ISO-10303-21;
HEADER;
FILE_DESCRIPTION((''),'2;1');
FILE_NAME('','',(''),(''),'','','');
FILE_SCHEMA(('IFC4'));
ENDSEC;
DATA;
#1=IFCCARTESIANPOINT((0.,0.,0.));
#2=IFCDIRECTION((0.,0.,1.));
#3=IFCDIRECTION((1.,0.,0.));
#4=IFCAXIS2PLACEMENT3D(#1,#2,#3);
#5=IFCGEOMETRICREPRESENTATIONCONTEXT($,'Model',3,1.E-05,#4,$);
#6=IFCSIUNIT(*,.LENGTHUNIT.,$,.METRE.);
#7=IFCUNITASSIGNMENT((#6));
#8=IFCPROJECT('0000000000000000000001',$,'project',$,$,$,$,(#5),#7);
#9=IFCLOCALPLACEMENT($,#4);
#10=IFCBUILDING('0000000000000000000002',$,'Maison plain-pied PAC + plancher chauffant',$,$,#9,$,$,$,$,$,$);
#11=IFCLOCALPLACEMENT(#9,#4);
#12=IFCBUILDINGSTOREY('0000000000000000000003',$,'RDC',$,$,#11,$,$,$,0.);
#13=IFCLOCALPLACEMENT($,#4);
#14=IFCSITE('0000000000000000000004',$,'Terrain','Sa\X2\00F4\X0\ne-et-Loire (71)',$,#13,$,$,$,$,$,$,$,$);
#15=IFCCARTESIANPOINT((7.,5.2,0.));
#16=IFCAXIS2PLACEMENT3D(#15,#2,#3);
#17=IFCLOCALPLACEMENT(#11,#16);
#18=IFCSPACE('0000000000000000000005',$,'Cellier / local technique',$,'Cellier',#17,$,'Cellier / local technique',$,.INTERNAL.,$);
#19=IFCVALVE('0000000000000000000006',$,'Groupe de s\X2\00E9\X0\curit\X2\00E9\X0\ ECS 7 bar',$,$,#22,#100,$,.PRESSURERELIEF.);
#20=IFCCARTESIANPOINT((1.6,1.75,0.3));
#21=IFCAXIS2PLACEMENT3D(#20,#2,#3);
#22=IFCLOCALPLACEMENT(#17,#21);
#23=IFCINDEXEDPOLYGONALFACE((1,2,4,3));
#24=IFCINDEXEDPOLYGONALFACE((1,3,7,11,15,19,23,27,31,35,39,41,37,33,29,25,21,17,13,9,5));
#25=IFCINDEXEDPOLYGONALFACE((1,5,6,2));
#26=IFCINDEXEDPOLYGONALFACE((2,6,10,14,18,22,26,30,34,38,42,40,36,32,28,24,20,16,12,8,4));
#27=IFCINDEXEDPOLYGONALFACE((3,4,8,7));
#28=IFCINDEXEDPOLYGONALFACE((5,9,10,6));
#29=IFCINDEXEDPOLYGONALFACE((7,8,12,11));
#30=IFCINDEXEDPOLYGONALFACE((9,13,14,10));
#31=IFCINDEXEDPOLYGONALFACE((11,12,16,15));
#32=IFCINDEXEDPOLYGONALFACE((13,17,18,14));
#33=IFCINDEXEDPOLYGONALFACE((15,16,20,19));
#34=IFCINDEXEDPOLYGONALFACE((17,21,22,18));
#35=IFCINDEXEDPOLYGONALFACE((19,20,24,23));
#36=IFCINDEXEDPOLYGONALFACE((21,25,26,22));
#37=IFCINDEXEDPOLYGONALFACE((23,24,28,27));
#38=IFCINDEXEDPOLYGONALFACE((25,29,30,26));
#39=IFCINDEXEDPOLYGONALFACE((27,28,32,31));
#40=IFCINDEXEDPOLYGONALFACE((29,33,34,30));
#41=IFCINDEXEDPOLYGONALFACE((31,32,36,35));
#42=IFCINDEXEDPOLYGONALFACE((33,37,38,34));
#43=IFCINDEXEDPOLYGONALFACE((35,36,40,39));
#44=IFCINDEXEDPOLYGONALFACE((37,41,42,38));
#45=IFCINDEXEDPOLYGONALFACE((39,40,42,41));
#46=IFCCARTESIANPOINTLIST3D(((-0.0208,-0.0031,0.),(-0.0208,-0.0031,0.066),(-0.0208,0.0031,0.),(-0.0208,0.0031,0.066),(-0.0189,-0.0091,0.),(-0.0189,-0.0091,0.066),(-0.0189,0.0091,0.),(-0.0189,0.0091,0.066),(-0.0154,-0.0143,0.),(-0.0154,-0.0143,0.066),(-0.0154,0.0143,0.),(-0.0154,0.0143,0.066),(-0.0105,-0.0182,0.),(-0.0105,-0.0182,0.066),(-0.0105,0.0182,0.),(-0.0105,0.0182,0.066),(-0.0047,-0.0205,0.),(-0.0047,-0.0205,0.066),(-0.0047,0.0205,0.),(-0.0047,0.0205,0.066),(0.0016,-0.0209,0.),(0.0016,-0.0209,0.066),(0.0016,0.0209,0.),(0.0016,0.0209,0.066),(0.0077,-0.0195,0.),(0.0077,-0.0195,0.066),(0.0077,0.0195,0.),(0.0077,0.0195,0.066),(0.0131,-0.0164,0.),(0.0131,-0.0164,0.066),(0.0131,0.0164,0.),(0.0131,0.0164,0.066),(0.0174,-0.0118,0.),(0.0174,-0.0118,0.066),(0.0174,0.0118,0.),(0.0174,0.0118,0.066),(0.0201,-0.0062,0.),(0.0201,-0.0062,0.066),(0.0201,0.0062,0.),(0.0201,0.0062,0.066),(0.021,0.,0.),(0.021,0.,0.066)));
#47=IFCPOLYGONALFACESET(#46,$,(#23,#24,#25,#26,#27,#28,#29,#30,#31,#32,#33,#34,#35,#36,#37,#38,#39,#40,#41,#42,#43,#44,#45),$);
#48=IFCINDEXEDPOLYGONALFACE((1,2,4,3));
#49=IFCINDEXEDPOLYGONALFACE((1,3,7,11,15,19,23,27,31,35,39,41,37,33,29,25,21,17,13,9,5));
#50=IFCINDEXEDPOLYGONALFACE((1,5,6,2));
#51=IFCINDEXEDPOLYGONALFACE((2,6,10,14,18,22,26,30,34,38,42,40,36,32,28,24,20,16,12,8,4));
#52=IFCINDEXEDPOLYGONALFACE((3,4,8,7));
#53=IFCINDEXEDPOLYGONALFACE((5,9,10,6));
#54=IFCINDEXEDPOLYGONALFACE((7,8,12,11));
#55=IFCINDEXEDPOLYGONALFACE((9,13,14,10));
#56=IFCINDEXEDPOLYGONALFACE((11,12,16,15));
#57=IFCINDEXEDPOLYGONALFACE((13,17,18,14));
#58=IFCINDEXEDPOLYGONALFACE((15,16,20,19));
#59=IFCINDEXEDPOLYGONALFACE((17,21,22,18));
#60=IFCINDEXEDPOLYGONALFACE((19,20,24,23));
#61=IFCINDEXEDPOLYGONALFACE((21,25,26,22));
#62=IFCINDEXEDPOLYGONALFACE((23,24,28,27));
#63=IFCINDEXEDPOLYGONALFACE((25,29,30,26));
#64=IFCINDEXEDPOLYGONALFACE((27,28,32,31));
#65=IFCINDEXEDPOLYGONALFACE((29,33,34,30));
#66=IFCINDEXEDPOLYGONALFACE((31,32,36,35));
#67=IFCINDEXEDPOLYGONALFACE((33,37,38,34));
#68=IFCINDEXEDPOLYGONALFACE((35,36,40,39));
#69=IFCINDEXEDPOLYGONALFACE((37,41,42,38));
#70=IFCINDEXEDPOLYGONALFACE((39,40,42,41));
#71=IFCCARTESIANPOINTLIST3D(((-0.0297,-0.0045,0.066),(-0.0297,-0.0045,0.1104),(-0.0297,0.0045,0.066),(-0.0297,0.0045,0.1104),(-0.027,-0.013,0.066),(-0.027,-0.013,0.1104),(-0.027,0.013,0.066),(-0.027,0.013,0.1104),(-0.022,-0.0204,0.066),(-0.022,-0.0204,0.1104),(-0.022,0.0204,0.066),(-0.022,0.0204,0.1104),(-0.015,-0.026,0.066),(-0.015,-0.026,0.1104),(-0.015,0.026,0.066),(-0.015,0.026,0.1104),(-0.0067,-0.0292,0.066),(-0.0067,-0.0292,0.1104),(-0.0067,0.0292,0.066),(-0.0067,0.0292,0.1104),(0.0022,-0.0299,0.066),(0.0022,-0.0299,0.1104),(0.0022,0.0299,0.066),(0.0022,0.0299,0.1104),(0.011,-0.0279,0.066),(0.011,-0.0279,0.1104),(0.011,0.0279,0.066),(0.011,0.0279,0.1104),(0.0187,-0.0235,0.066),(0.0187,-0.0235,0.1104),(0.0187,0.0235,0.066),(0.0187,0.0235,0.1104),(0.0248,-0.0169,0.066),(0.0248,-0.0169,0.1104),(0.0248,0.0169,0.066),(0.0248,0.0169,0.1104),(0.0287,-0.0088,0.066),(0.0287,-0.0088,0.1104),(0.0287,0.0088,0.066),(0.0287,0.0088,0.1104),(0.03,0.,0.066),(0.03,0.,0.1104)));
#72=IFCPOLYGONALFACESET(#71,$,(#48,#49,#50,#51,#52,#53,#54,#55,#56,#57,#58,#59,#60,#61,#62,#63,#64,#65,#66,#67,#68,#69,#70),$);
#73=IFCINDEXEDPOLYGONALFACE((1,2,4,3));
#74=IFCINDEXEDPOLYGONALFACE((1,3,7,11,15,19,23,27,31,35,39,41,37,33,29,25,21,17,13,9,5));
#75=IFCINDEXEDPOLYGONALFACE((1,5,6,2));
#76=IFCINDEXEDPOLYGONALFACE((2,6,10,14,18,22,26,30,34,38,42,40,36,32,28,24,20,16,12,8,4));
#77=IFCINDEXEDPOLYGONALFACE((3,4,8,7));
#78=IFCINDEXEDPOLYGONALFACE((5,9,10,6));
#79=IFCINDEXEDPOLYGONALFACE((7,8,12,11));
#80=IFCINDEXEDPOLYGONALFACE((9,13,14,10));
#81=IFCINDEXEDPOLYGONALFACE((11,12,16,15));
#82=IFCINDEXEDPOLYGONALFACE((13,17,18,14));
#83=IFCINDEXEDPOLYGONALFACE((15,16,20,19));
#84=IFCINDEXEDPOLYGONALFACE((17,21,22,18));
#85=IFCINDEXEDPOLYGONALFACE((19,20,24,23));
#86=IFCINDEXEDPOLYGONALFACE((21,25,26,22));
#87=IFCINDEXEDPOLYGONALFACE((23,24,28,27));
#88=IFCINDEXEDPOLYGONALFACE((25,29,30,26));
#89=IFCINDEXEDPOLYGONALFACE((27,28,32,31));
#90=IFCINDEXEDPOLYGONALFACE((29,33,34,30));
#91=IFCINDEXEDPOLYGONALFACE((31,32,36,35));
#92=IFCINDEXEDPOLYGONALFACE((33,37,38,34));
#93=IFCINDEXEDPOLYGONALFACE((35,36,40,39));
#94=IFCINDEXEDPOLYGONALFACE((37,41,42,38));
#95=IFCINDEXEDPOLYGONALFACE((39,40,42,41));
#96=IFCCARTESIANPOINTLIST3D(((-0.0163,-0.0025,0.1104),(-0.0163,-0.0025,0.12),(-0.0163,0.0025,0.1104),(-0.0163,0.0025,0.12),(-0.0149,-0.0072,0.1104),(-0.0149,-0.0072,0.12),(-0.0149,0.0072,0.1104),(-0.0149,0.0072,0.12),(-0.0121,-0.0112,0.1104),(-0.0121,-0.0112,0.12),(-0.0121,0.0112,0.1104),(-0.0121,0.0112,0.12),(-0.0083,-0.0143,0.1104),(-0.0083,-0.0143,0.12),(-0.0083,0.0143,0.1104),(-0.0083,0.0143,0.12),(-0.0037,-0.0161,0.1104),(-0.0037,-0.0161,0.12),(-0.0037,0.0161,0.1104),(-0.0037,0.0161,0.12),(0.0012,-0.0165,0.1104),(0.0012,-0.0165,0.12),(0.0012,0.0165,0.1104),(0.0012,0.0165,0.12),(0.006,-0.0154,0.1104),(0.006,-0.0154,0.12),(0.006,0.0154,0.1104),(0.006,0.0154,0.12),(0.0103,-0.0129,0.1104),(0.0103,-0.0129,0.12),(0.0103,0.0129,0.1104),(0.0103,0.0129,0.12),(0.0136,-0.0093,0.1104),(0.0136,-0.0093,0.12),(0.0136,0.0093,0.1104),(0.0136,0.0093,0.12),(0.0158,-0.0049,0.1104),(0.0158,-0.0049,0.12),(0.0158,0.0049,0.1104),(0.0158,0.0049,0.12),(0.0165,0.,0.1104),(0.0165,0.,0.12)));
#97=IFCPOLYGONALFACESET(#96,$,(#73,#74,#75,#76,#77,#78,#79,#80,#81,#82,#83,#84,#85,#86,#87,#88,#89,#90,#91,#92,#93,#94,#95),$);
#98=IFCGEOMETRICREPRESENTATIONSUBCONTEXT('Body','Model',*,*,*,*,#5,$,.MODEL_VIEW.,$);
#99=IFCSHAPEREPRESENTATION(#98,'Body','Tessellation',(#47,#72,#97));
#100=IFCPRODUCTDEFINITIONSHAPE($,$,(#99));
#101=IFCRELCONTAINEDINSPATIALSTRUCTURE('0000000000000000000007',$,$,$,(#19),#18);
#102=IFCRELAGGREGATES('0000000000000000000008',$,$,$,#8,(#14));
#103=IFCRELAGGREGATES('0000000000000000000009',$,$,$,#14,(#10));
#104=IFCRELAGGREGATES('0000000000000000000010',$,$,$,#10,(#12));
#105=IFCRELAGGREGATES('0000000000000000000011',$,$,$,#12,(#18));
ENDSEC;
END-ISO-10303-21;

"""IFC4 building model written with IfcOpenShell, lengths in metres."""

from ifc_helpers import new_model, si_unit, frame, origin_with_axes, place, context, subcontext, project, spatial, circle, extrude, element, save


model = new_model("IFC4")

# Units and contexts
model_context = context("Model", 3, precision=1e-05, world=origin_with_axes())
body_context = subcontext(model_context, "Body", "Model", "MODEL_VIEW")
ifc_project = project(units=[si_unit("LENGTHUNIT", "METRE")], contexts=[model_context])

# Site, building, storey
site_placement = place(None, origin_with_axes())
site = spatial("IfcSite", under=ifc_project, at=site_placement, Name="Terrain", Description="Saône-et-Loire (71)")
building_placement = place(None, origin_with_axes())
building = spatial("IfcBuilding", under=site, at=building_placement, Name="Maison plain-pied PAC + plancher chauffant")
storey_placement = place(building_placement, origin_with_axes())
storey = spatial("IfcBuildingStorey", under=building, at=storey_placement, Name="RDC", Elevation=0.0)

# Shared definitions
space_1_placement = place(storey_placement, frame((7.0, 5.2, 0.0), z_axis=(0.0, 0.0, 1.0), x_axis=(1.0, 0.0, 0.0)))
space_1 = spatial("IfcSpace", under=storey, at=space_1_placement, Name="Cellier / local technique", ObjectType="Cellier", LongName="Cellier / local technique", PredefinedType="INTERNAL")

# Valve
valve_placement = place(space_1_placement, frame((1.6, 1.75, 0.3), z_axis=(0.0, 0.0, 1.0), x_axis=(1.0, 0.0, 0.0)))
element("IfcValve", 1, at=valve_placement, inside=space_1, Name="Groupe de sécurité ECS 7 bar", PredefinedType="PRESSURERELIEF", context=body_context, shape_type="SweptSolid", body=[
    extrude(circle(Radius=0.021), origin_with_axes(), (0.0, 0.0, 1.0), 0.066),
    extrude(circle(Radius=0.03), frame((0.0, 0.0, 0.066), z_axis=(0.0, 0.0, 1.0), x_axis=(1.0, 0.0, 0.0)), (0.0, 0.0, 1.0), 0.0444),
    extrude(circle(Radius=0.0165), frame((0.0, 0.0, 0.1104), z_axis=(0.0, 0.0, 1.0), x_axis=(1.0, 0.0, 0.0)), (0.0, 0.0, 1.0), 0.0096),
])

save(model, "model.ifc")
